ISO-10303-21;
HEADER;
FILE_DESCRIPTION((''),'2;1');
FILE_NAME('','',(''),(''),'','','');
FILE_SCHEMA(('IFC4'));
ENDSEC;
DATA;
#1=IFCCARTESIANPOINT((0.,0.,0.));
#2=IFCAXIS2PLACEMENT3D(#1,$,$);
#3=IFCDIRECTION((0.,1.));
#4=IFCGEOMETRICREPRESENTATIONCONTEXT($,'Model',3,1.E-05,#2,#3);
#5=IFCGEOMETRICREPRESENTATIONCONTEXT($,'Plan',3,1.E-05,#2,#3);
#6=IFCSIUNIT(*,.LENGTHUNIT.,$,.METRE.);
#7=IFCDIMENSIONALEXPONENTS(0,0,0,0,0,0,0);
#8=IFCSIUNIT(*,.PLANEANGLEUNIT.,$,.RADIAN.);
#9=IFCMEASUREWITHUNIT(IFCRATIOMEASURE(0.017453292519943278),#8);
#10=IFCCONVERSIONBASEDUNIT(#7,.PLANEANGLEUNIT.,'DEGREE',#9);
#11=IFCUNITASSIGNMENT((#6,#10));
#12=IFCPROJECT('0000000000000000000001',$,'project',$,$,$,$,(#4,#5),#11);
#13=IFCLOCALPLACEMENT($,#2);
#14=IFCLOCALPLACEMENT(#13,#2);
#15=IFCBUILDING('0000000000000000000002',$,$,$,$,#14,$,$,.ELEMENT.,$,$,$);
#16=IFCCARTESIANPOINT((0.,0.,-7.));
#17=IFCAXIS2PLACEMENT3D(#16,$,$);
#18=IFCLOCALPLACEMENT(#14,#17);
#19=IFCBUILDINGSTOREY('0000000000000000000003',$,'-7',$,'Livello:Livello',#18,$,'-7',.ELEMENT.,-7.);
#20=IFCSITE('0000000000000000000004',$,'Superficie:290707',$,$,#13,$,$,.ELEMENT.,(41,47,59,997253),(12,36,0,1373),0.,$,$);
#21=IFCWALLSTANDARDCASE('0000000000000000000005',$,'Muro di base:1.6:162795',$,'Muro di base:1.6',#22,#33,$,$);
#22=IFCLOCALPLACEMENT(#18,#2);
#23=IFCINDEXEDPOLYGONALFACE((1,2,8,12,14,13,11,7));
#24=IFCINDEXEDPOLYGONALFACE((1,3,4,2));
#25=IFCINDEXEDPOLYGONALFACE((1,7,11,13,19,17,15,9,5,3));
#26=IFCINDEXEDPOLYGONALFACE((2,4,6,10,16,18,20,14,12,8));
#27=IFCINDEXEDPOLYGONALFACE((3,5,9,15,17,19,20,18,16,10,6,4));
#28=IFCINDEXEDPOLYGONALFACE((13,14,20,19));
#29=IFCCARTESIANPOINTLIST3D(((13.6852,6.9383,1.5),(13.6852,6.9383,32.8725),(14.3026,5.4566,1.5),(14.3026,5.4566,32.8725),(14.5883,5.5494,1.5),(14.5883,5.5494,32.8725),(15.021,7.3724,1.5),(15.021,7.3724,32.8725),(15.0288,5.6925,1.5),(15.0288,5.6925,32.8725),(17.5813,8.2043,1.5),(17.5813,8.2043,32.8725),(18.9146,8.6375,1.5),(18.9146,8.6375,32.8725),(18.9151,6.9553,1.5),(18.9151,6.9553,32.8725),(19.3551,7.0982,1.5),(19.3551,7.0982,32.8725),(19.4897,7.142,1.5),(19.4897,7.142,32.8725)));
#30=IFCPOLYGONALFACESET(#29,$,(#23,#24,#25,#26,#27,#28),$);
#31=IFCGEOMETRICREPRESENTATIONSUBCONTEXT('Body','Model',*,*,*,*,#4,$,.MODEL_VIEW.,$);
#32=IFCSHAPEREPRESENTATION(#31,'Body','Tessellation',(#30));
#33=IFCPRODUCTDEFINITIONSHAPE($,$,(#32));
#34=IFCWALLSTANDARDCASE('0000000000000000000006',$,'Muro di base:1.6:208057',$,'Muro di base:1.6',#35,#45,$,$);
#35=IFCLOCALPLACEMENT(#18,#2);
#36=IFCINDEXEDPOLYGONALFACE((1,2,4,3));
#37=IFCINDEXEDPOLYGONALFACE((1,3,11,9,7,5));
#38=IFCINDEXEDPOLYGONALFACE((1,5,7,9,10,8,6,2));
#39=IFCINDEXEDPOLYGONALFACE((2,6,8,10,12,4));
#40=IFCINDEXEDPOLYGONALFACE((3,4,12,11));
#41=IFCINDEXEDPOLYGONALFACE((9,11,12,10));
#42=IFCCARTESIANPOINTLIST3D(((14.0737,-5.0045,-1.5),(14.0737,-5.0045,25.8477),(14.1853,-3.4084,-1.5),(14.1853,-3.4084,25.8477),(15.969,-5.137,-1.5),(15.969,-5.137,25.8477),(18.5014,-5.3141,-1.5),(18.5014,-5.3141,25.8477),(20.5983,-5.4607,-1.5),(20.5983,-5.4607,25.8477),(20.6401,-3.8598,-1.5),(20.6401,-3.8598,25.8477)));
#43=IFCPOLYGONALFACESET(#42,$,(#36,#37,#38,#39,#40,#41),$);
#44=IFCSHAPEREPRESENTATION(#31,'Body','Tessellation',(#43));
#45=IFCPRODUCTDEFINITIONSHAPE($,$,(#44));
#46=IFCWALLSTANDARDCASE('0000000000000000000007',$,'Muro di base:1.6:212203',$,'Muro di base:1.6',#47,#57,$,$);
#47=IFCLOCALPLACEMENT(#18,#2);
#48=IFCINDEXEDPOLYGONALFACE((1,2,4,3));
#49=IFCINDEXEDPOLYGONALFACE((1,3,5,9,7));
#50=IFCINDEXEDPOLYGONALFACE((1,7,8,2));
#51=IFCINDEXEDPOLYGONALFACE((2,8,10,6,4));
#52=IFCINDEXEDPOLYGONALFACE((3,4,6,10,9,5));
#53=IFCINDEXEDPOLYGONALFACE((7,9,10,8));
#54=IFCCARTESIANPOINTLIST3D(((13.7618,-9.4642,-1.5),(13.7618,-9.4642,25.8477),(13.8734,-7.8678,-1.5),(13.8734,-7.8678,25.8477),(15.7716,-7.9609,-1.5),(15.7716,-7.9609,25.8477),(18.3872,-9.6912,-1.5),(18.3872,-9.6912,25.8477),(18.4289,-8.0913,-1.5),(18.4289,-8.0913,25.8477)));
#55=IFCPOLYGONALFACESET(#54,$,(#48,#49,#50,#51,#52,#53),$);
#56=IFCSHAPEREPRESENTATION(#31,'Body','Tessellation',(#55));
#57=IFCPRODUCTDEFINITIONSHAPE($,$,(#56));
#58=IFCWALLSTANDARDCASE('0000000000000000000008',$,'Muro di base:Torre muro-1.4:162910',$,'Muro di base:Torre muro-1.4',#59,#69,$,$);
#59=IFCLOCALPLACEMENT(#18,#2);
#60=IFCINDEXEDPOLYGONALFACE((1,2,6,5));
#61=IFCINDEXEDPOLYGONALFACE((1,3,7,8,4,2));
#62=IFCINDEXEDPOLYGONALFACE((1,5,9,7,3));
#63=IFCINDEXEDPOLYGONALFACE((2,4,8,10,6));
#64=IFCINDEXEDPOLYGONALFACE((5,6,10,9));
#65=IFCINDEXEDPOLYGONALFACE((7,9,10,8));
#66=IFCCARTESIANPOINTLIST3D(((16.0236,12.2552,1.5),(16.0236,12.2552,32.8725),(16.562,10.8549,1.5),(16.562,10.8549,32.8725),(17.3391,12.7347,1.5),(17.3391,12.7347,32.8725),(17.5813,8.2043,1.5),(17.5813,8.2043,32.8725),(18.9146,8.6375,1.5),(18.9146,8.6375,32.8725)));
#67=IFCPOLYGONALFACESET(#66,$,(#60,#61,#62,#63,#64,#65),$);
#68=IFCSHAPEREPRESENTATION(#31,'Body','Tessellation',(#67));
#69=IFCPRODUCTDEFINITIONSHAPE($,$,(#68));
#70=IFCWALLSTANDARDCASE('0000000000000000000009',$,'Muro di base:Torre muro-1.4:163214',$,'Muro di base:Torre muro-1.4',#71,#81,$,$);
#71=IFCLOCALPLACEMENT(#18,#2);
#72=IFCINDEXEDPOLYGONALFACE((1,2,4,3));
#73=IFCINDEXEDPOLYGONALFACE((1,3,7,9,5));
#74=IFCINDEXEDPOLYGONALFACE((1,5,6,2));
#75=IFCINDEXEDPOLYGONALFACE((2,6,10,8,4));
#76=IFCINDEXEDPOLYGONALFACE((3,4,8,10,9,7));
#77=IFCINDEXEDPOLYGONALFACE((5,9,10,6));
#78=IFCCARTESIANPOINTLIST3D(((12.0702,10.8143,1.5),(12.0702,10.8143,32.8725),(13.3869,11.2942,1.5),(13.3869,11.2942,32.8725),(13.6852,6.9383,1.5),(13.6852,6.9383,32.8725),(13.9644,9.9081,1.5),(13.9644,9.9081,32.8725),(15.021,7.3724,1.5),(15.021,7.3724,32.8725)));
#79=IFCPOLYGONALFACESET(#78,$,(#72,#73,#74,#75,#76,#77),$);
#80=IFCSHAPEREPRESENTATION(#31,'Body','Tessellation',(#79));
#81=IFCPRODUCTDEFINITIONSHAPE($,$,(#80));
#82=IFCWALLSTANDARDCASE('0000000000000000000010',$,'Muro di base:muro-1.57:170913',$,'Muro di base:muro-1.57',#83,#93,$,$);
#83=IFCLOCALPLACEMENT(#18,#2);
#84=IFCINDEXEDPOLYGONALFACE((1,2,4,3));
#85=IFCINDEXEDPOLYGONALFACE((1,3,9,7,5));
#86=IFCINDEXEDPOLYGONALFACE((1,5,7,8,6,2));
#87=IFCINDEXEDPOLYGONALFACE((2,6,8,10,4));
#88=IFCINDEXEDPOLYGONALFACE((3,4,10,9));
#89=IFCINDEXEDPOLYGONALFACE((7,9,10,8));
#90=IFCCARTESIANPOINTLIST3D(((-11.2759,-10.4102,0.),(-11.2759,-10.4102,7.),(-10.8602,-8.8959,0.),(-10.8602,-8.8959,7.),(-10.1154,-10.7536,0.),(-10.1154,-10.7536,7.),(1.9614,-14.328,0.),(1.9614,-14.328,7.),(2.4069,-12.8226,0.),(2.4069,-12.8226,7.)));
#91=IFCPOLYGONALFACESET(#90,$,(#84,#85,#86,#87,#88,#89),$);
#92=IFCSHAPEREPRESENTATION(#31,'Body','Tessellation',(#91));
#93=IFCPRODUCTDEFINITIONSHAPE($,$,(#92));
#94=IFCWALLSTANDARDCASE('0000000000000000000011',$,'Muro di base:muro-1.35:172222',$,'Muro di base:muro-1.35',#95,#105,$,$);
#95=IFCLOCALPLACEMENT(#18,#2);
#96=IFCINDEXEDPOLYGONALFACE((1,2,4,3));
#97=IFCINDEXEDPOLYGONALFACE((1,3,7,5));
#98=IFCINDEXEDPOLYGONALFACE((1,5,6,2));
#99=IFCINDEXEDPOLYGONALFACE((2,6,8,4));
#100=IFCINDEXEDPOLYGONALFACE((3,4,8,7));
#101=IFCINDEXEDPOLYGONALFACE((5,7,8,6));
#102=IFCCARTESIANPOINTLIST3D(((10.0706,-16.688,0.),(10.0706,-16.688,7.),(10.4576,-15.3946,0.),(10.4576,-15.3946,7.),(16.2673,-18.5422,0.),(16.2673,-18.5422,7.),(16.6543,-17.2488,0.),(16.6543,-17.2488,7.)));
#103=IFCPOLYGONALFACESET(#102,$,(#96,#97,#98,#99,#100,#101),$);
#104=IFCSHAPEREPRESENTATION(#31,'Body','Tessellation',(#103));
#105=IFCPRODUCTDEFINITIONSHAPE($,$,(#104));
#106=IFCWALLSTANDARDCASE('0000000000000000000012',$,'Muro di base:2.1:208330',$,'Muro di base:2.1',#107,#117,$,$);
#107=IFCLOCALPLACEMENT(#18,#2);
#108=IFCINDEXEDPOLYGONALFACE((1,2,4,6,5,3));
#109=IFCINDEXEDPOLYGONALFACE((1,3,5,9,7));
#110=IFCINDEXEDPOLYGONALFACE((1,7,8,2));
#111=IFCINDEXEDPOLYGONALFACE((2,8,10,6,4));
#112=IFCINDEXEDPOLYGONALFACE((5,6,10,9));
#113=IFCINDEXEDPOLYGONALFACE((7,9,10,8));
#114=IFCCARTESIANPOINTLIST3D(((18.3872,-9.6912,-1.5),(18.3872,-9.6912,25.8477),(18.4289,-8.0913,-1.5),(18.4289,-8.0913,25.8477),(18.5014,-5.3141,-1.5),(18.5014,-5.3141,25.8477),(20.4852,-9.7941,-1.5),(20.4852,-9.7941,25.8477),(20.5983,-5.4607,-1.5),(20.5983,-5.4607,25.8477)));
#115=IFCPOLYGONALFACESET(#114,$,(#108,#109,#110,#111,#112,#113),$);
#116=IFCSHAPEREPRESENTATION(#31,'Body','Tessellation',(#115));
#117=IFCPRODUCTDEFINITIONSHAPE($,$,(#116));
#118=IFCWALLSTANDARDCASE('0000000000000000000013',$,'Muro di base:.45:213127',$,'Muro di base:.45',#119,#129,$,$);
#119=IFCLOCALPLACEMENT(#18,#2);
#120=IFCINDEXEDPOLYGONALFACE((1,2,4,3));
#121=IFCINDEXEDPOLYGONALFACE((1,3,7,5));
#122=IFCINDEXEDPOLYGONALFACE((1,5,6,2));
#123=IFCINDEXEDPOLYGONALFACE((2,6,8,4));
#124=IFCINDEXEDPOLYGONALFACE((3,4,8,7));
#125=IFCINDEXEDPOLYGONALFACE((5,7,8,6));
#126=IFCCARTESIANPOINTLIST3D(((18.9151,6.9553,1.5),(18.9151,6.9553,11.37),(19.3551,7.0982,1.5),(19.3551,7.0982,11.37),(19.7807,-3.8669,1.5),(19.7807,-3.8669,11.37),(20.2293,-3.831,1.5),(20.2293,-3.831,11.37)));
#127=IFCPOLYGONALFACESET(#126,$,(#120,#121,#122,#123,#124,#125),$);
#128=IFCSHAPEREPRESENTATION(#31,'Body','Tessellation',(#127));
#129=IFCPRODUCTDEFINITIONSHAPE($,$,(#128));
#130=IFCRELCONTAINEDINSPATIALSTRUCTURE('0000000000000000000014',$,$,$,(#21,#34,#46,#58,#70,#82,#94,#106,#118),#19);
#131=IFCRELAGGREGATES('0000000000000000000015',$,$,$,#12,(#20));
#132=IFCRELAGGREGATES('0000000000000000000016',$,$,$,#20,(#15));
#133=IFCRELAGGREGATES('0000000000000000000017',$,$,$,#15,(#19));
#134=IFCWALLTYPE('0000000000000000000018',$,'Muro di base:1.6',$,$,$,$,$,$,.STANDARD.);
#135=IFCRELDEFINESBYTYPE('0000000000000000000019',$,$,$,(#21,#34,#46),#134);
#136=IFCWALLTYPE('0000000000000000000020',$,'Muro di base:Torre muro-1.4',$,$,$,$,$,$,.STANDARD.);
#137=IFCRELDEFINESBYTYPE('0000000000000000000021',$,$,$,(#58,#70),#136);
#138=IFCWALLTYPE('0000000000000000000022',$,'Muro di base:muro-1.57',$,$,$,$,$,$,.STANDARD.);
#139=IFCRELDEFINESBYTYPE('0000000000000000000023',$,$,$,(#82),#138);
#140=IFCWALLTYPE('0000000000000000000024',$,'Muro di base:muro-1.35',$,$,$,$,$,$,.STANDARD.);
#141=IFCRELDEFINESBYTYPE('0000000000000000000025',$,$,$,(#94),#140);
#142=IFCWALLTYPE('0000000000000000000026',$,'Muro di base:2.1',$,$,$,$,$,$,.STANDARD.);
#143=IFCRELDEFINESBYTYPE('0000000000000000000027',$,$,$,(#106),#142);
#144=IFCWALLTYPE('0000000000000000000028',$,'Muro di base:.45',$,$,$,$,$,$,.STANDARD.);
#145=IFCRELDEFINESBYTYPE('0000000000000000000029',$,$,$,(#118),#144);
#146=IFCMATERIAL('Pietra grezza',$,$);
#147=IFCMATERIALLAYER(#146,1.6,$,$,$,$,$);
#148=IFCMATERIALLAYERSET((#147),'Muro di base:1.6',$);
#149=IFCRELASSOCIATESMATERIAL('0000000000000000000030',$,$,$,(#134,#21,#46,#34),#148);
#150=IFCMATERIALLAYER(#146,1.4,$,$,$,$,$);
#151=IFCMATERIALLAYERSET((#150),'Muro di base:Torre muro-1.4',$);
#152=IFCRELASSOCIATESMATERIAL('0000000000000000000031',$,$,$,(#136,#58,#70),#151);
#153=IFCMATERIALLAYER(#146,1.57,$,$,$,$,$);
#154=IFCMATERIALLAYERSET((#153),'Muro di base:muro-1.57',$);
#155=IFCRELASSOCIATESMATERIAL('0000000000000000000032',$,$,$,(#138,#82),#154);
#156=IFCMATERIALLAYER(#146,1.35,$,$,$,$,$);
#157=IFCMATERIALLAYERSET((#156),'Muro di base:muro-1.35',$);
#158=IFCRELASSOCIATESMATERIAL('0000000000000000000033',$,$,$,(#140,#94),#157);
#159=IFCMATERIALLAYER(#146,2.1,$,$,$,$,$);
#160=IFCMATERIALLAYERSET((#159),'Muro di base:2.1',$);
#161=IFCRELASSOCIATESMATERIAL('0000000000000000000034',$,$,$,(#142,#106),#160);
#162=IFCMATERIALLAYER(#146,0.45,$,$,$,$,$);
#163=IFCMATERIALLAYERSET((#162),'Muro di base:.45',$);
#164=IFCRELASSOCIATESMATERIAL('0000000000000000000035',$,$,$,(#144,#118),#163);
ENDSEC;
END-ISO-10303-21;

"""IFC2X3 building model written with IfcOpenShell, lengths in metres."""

from ifc_helpers import new_model, entity, si_unit, converted_unit, direction, frame, frame_2d, origin, place, context, subcontext, project, spatial, polyline, rectangle, outline, extrude, material, layer, layer_set, layer_usage, type_object, element, save


model = new_model("IFC2X3")

# Units and contexts
model_context = context("Model", 3, precision=1e-05, world=origin(), true_north=direction((0.0, 1.0)))
plan_context = context("Plan", 3, precision=1e-05, world=origin(), true_north=direction((0.0, 1.0)))
body_context = subcontext(model_context, "Body", "Model", "MODEL_VIEW")
ifc_project = project(units=[si_unit("LENGTHUNIT", "METRE"), converted_unit("PLANEANGLEUNIT", "DEGREE", entity("IfcRatioMeasure", 0.017453292519943278), si_unit("PLANEANGLEUNIT", "RADIAN"), dimensions=[0, 0, 0, 0, 0, 0, 0])], contexts=[model_context, plan_context])

# Site, building, storey
site_placement = place(None, origin())
site = spatial("IfcSite", under=ifc_project, at=site_placement, Name="Superficie:290707", CompositionType="ELEMENT", RefLatitude=(41, 47, 59, 997253), RefLongitude=(12, 36, 0, 1373), RefElevation=0.0)
building_placement = place(site_placement, origin())
building = spatial("IfcBuilding", under=site, at=building_placement, CompositionType="ELEMENT")
storey_placement = place(building_placement, frame((0.0, 0.0, -7.0)))
storey = spatial("IfcBuildingStorey", under=building, at=storey_placement, Name="-7", ObjectType="Livello:Livello", LongName="-7", CompositionType="ELEMENT", Elevation=-7.0)

# Walls
ifc_material_1 = material(Name="Pietra grezza")
ifc_layer_1 = layer(ifc_material_1, 1.6)
ifc_layer_set_1 = layer_set([ifc_layer_1], Name="Muro di base:1.6")
ifc_layer_usage_1 = layer_usage(ifc_layer_set_1, "AXIS2", "POSITIVE", -0.8)
wall_type_1 = type_object("IfcWallType", Name="Muro di base:1.6", PredefinedType="STANDARD", material=ifc_layer_set_1)
wall_1_placement = place(storey_placement, frame((13.9324, 6.1775, 1.5), z_axis=(0.0, 0.0, 1.0), x_axis=(0.951057, 0.309017, 0.0)))
element("IfcWallStandardCase", 1, at=wall_1_placement, inside=storey, type_object=wall_type_1, material=ifc_layer_usage_1, Name="Muro di base:1.6:162795", ObjectType="Muro di base:1.6", context=body_context, shape_type="SweptSolid", body=[
    extrude(outline(polyline([(5.5834, -0.8), (5.4986, 0.8), (4.0966, 0.8), (1.4046, 0.8), (0.0, 0.8), (0.1293, -0.8), (0.4297, -0.8), (0.8929, -0.8), (4.9792, -0.8), (5.4418, -0.8), (5.5834, -0.8)])), origin(), (0.0, 0.0, 1.0), 31.3725),
])
ifc_layer_usage_2 = layer_usage(ifc_layer_set_1, "AXIS2", "NEGATIVE", 0.8)
wall_2_placement = place(storey_placement, frame((14.1295, -4.2064, -1.5), z_axis=(0.0, 0.0, 1.0), x_axis=(0.997564, -0.069756, 0.0)))
element("IfcWallStandardCase", 2, at=wall_2_placement, inside=storey, type_object=wall_type_1, material=ifc_layer_usage_2, Name="Muro di base:1.6:208057", ObjectType="Muro di base:1.6", context=body_context, shape_type="SweptSolid", body=[
    extrude(outline(polyline([(6.5406, -0.8), (6.4706, 0.8), (0.0, 0.8), (0.0, -0.8), (1.9, -0.8), (4.4386, -0.8), (6.5406, -0.8)])), origin(), (0.0, 0.0, 1.0), 27.3477),
])
wall_3_placement = place(storey_placement, frame((13.801, -8.6652, -1.5), z_axis=(0.0, 0.0, 1.0), x_axis=(0.998798, -0.049006, 0.0)))
element("IfcWallStandardCase", 3, at=wall_3_placement, inside=storey, type_object=wall_type_1, material=ifc_layer_usage_1, Name="Muro di base:1.6:212203", ObjectType="Muro di base:1.6", context=body_context, shape_type="SweptSolid", body=[
    extrude(outline(polyline([(4.631, -0.8), (4.5942, 0.8), (1.9337, 0.8), (0.0333, 0.8), (0.0, -0.8), (4.631, -0.8)])), origin(), (0.0, 0.0, 1.0), 27.3477),
])
ifc_layer_2 = layer(ifc_material_1, 1.4)
ifc_layer_set_2 = layer_set([ifc_layer_2], Name="Muro di base:Torre muro-1.4")
ifc_layer_usage_3 = layer_usage(ifc_layer_set_2, "AXIS2", "POSITIVE", -0.7)
wall_type_2 = type_object("IfcWallType", Name="Muro di base:Torre muro-1.4", PredefinedType="STANDARD", material=ifc_layer_set_2)
wall_4_placement = place(storey_placement, frame((18.2613, 8.3862, 1.5), z_axis=(0.0, 0.0, 1.0), x_axis=(-0.358912, 0.933371, 0.0)))
element("IfcWallStandardCase", 4, at=wall_4_placement, inside=storey, type_object=wall_type_2, material=ifc_layer_usage_3, Name="Muro di base:Torre muro-1.4:162910", ObjectType="Muro di base:Torre muro-1.4", context=body_context, shape_type="SweptSolid", body=[
    extrude(outline(polyline([(4.3897, -0.7), (4.4143, 0.7), (2.9141, 0.7), (0.0742, 0.7), (0.0, -0.7), (4.3897, -0.7)])), origin(), (0.0, 0.0, 1.0), 31.3725),
])
wall_5_placement = place(storey_placement, frame((12.7163, 11.0835, 1.5), z_axis=(0.0, 0.0, 1.0), x_axis=(0.384621, -0.923075, 0.0)))
element("IfcWallStandardCase", 5, at=wall_5_placement, inside=storey, type_object=wall_type_2, material=ifc_layer_usage_3, Name="Muro di base:Torre muro-1.4:163214", ObjectType="Muro di base:Torre muro-1.4", context=body_context, shape_type="SweptSolid", body=[
    extrude(outline(polyline([(4.199, -0.7), (4.3121, 0.7), (1.565, 0.7), (0.0634, 0.7), (0.0, -0.7), (4.199, -0.7)])), origin(), (0.0, 0.0, 1.0), 31.3725),
])
ifc_layer_3 = layer(ifc_material_1, 1.57)
ifc_layer_set_3 = layer_set([ifc_layer_3], Name="Muro di base:muro-1.57")
ifc_layer_usage_4 = layer_usage(ifc_layer_set_3, "AXIS2", "POSITIVE", -0.785)
wall_type_3 = type_object("IfcWallType", Name="Muro di base:muro-1.57", PredefinedType="STANDARD", material=ifc_layer_set_3)
wall_6_placement = place(storey_placement, frame((2.1841, -13.5753, 0.0), z_axis=(0.0, 0.0, 1.0), x_axis=(-0.958882, 0.283805, 0.0)))
element("IfcWallStandardCase", 6, at=wall_6_placement, inside=storey, type_object=wall_type_3, material=ifc_layer_usage_4, Name="Muro di base:muro-1.57:170913", ObjectType="Muro di base:muro-1.57", context=body_context, shape_type="SweptSolid", body=[
    extrude(outline(polyline([(13.836, -0.785), (13.8049, 0.785), (12.5946, 0.785), (0.0, 0.785), (0.0, -0.785), (13.836, -0.785)])), origin(), (0.0, 0.0, 1.0), 7.0),
])
ifc_layer_4 = layer(ifc_material_1, 1.35)
ifc_layer_set_4 = layer_set([ifc_layer_4], Name="Muro di base:muro-1.35")
ifc_layer_usage_5 = layer_usage(ifc_layer_set_4, "AXIS2", "NEGATIVE", 0.675)
wall_type_4 = type_object("IfcWallType", Name="Muro di base:muro-1.35", PredefinedType="STANDARD", material=ifc_layer_set_4)
wall_7_placement = place(storey_placement, frame((10.2641, -16.0413, 0.0), z_axis=(0.0, 0.0, 1.0), x_axis=(0.95803, -0.286666, 0.0)))
element("IfcWallStandardCase", 7, at=wall_7_placement, inside=storey, type_object=wall_type_4, material=ifc_layer_usage_5, Name="Muro di base:muro-1.35:172222", ObjectType="Muro di base:muro-1.35", context=body_context, shape_type="SweptSolid", body=[
    extrude(rectangle(XDim=1.35, YDim=6.4682, at=frame_2d((3.2341, 0.0), x_axis=(0.0, 1.0))), origin(), (0.0, 0.0, 1.0), 7.0),
])
ifc_layer_5 = layer(ifc_material_1, 2.1)
ifc_layer_set_5 = layer_set([ifc_layer_5], Name="Muro di base:2.1")
ifc_layer_usage_6 = layer_usage(ifc_layer_set_5, "AXIS2", "NEGATIVE", 1.05)
wall_type_5 = type_object("IfcWallType", Name="Muro di base:2.1", PredefinedType="STANDARD", material=ifc_layer_set_5)
wall_8_placement = place(storey_placement, frame((19.5511, -5.3415, -1.5), z_axis=(0.0, 0.0, 1.0), x_axis=(-0.026085, -0.99966, 0.0)))
element("IfcWallStandardCase", 8, at=wall_8_placement, inside=storey, type_object=wall_type_5, material=ifc_layer_usage_6, Name="Muro di base:2.1:208330", ObjectType="Muro di base:2.1", context=body_context, shape_type="SweptSolid", body=[
    extrude(outline(polyline([(4.3785, -1.05), (4.4267, 1.05), (0.0919, 1.05), (0.0, -1.05), (2.7781, -1.05), (4.3785, -1.05)])), origin(), (0.0, 0.0, 1.0), 27.3477),
])
ifc_layer_6 = layer(ifc_material_1, 0.45)
ifc_layer_set_6 = layer_set([ifc_layer_6], Name="Muro di base:.45")
ifc_layer_usage_7 = layer_usage(ifc_layer_set_6, "AXIS2", "NEGATIVE", 0.225)
wall_type_6 = type_object("IfcWallType", Name="Muro di base:.45", PredefinedType="STANDARD", material=ifc_layer_set_6)
wall_9_placement = place(storey_placement, frame((20.005, -3.849, 1.5), z_axis=(0.0, 0.0, 1.0), x_axis=(-0.079735, 0.996816, 0.0)))
element("IfcWallStandardCase", 9, at=wall_9_placement, inside=storey, type_object=wall_type_6, material=ifc_layer_usage_7, Name="Muro di base:.45:213127", ObjectType="Muro di base:.45", context=body_context, shape_type="SweptSolid", body=[
    extrude(outline(polyline([(10.9642, -0.225), (10.8568, 0.225), (0.0, 0.225), (0.0, -0.225), (10.9642, -0.225)])), origin(), (0.0, 0.0, 1.0), 9.87),
])

save(model, "model.ifc")
